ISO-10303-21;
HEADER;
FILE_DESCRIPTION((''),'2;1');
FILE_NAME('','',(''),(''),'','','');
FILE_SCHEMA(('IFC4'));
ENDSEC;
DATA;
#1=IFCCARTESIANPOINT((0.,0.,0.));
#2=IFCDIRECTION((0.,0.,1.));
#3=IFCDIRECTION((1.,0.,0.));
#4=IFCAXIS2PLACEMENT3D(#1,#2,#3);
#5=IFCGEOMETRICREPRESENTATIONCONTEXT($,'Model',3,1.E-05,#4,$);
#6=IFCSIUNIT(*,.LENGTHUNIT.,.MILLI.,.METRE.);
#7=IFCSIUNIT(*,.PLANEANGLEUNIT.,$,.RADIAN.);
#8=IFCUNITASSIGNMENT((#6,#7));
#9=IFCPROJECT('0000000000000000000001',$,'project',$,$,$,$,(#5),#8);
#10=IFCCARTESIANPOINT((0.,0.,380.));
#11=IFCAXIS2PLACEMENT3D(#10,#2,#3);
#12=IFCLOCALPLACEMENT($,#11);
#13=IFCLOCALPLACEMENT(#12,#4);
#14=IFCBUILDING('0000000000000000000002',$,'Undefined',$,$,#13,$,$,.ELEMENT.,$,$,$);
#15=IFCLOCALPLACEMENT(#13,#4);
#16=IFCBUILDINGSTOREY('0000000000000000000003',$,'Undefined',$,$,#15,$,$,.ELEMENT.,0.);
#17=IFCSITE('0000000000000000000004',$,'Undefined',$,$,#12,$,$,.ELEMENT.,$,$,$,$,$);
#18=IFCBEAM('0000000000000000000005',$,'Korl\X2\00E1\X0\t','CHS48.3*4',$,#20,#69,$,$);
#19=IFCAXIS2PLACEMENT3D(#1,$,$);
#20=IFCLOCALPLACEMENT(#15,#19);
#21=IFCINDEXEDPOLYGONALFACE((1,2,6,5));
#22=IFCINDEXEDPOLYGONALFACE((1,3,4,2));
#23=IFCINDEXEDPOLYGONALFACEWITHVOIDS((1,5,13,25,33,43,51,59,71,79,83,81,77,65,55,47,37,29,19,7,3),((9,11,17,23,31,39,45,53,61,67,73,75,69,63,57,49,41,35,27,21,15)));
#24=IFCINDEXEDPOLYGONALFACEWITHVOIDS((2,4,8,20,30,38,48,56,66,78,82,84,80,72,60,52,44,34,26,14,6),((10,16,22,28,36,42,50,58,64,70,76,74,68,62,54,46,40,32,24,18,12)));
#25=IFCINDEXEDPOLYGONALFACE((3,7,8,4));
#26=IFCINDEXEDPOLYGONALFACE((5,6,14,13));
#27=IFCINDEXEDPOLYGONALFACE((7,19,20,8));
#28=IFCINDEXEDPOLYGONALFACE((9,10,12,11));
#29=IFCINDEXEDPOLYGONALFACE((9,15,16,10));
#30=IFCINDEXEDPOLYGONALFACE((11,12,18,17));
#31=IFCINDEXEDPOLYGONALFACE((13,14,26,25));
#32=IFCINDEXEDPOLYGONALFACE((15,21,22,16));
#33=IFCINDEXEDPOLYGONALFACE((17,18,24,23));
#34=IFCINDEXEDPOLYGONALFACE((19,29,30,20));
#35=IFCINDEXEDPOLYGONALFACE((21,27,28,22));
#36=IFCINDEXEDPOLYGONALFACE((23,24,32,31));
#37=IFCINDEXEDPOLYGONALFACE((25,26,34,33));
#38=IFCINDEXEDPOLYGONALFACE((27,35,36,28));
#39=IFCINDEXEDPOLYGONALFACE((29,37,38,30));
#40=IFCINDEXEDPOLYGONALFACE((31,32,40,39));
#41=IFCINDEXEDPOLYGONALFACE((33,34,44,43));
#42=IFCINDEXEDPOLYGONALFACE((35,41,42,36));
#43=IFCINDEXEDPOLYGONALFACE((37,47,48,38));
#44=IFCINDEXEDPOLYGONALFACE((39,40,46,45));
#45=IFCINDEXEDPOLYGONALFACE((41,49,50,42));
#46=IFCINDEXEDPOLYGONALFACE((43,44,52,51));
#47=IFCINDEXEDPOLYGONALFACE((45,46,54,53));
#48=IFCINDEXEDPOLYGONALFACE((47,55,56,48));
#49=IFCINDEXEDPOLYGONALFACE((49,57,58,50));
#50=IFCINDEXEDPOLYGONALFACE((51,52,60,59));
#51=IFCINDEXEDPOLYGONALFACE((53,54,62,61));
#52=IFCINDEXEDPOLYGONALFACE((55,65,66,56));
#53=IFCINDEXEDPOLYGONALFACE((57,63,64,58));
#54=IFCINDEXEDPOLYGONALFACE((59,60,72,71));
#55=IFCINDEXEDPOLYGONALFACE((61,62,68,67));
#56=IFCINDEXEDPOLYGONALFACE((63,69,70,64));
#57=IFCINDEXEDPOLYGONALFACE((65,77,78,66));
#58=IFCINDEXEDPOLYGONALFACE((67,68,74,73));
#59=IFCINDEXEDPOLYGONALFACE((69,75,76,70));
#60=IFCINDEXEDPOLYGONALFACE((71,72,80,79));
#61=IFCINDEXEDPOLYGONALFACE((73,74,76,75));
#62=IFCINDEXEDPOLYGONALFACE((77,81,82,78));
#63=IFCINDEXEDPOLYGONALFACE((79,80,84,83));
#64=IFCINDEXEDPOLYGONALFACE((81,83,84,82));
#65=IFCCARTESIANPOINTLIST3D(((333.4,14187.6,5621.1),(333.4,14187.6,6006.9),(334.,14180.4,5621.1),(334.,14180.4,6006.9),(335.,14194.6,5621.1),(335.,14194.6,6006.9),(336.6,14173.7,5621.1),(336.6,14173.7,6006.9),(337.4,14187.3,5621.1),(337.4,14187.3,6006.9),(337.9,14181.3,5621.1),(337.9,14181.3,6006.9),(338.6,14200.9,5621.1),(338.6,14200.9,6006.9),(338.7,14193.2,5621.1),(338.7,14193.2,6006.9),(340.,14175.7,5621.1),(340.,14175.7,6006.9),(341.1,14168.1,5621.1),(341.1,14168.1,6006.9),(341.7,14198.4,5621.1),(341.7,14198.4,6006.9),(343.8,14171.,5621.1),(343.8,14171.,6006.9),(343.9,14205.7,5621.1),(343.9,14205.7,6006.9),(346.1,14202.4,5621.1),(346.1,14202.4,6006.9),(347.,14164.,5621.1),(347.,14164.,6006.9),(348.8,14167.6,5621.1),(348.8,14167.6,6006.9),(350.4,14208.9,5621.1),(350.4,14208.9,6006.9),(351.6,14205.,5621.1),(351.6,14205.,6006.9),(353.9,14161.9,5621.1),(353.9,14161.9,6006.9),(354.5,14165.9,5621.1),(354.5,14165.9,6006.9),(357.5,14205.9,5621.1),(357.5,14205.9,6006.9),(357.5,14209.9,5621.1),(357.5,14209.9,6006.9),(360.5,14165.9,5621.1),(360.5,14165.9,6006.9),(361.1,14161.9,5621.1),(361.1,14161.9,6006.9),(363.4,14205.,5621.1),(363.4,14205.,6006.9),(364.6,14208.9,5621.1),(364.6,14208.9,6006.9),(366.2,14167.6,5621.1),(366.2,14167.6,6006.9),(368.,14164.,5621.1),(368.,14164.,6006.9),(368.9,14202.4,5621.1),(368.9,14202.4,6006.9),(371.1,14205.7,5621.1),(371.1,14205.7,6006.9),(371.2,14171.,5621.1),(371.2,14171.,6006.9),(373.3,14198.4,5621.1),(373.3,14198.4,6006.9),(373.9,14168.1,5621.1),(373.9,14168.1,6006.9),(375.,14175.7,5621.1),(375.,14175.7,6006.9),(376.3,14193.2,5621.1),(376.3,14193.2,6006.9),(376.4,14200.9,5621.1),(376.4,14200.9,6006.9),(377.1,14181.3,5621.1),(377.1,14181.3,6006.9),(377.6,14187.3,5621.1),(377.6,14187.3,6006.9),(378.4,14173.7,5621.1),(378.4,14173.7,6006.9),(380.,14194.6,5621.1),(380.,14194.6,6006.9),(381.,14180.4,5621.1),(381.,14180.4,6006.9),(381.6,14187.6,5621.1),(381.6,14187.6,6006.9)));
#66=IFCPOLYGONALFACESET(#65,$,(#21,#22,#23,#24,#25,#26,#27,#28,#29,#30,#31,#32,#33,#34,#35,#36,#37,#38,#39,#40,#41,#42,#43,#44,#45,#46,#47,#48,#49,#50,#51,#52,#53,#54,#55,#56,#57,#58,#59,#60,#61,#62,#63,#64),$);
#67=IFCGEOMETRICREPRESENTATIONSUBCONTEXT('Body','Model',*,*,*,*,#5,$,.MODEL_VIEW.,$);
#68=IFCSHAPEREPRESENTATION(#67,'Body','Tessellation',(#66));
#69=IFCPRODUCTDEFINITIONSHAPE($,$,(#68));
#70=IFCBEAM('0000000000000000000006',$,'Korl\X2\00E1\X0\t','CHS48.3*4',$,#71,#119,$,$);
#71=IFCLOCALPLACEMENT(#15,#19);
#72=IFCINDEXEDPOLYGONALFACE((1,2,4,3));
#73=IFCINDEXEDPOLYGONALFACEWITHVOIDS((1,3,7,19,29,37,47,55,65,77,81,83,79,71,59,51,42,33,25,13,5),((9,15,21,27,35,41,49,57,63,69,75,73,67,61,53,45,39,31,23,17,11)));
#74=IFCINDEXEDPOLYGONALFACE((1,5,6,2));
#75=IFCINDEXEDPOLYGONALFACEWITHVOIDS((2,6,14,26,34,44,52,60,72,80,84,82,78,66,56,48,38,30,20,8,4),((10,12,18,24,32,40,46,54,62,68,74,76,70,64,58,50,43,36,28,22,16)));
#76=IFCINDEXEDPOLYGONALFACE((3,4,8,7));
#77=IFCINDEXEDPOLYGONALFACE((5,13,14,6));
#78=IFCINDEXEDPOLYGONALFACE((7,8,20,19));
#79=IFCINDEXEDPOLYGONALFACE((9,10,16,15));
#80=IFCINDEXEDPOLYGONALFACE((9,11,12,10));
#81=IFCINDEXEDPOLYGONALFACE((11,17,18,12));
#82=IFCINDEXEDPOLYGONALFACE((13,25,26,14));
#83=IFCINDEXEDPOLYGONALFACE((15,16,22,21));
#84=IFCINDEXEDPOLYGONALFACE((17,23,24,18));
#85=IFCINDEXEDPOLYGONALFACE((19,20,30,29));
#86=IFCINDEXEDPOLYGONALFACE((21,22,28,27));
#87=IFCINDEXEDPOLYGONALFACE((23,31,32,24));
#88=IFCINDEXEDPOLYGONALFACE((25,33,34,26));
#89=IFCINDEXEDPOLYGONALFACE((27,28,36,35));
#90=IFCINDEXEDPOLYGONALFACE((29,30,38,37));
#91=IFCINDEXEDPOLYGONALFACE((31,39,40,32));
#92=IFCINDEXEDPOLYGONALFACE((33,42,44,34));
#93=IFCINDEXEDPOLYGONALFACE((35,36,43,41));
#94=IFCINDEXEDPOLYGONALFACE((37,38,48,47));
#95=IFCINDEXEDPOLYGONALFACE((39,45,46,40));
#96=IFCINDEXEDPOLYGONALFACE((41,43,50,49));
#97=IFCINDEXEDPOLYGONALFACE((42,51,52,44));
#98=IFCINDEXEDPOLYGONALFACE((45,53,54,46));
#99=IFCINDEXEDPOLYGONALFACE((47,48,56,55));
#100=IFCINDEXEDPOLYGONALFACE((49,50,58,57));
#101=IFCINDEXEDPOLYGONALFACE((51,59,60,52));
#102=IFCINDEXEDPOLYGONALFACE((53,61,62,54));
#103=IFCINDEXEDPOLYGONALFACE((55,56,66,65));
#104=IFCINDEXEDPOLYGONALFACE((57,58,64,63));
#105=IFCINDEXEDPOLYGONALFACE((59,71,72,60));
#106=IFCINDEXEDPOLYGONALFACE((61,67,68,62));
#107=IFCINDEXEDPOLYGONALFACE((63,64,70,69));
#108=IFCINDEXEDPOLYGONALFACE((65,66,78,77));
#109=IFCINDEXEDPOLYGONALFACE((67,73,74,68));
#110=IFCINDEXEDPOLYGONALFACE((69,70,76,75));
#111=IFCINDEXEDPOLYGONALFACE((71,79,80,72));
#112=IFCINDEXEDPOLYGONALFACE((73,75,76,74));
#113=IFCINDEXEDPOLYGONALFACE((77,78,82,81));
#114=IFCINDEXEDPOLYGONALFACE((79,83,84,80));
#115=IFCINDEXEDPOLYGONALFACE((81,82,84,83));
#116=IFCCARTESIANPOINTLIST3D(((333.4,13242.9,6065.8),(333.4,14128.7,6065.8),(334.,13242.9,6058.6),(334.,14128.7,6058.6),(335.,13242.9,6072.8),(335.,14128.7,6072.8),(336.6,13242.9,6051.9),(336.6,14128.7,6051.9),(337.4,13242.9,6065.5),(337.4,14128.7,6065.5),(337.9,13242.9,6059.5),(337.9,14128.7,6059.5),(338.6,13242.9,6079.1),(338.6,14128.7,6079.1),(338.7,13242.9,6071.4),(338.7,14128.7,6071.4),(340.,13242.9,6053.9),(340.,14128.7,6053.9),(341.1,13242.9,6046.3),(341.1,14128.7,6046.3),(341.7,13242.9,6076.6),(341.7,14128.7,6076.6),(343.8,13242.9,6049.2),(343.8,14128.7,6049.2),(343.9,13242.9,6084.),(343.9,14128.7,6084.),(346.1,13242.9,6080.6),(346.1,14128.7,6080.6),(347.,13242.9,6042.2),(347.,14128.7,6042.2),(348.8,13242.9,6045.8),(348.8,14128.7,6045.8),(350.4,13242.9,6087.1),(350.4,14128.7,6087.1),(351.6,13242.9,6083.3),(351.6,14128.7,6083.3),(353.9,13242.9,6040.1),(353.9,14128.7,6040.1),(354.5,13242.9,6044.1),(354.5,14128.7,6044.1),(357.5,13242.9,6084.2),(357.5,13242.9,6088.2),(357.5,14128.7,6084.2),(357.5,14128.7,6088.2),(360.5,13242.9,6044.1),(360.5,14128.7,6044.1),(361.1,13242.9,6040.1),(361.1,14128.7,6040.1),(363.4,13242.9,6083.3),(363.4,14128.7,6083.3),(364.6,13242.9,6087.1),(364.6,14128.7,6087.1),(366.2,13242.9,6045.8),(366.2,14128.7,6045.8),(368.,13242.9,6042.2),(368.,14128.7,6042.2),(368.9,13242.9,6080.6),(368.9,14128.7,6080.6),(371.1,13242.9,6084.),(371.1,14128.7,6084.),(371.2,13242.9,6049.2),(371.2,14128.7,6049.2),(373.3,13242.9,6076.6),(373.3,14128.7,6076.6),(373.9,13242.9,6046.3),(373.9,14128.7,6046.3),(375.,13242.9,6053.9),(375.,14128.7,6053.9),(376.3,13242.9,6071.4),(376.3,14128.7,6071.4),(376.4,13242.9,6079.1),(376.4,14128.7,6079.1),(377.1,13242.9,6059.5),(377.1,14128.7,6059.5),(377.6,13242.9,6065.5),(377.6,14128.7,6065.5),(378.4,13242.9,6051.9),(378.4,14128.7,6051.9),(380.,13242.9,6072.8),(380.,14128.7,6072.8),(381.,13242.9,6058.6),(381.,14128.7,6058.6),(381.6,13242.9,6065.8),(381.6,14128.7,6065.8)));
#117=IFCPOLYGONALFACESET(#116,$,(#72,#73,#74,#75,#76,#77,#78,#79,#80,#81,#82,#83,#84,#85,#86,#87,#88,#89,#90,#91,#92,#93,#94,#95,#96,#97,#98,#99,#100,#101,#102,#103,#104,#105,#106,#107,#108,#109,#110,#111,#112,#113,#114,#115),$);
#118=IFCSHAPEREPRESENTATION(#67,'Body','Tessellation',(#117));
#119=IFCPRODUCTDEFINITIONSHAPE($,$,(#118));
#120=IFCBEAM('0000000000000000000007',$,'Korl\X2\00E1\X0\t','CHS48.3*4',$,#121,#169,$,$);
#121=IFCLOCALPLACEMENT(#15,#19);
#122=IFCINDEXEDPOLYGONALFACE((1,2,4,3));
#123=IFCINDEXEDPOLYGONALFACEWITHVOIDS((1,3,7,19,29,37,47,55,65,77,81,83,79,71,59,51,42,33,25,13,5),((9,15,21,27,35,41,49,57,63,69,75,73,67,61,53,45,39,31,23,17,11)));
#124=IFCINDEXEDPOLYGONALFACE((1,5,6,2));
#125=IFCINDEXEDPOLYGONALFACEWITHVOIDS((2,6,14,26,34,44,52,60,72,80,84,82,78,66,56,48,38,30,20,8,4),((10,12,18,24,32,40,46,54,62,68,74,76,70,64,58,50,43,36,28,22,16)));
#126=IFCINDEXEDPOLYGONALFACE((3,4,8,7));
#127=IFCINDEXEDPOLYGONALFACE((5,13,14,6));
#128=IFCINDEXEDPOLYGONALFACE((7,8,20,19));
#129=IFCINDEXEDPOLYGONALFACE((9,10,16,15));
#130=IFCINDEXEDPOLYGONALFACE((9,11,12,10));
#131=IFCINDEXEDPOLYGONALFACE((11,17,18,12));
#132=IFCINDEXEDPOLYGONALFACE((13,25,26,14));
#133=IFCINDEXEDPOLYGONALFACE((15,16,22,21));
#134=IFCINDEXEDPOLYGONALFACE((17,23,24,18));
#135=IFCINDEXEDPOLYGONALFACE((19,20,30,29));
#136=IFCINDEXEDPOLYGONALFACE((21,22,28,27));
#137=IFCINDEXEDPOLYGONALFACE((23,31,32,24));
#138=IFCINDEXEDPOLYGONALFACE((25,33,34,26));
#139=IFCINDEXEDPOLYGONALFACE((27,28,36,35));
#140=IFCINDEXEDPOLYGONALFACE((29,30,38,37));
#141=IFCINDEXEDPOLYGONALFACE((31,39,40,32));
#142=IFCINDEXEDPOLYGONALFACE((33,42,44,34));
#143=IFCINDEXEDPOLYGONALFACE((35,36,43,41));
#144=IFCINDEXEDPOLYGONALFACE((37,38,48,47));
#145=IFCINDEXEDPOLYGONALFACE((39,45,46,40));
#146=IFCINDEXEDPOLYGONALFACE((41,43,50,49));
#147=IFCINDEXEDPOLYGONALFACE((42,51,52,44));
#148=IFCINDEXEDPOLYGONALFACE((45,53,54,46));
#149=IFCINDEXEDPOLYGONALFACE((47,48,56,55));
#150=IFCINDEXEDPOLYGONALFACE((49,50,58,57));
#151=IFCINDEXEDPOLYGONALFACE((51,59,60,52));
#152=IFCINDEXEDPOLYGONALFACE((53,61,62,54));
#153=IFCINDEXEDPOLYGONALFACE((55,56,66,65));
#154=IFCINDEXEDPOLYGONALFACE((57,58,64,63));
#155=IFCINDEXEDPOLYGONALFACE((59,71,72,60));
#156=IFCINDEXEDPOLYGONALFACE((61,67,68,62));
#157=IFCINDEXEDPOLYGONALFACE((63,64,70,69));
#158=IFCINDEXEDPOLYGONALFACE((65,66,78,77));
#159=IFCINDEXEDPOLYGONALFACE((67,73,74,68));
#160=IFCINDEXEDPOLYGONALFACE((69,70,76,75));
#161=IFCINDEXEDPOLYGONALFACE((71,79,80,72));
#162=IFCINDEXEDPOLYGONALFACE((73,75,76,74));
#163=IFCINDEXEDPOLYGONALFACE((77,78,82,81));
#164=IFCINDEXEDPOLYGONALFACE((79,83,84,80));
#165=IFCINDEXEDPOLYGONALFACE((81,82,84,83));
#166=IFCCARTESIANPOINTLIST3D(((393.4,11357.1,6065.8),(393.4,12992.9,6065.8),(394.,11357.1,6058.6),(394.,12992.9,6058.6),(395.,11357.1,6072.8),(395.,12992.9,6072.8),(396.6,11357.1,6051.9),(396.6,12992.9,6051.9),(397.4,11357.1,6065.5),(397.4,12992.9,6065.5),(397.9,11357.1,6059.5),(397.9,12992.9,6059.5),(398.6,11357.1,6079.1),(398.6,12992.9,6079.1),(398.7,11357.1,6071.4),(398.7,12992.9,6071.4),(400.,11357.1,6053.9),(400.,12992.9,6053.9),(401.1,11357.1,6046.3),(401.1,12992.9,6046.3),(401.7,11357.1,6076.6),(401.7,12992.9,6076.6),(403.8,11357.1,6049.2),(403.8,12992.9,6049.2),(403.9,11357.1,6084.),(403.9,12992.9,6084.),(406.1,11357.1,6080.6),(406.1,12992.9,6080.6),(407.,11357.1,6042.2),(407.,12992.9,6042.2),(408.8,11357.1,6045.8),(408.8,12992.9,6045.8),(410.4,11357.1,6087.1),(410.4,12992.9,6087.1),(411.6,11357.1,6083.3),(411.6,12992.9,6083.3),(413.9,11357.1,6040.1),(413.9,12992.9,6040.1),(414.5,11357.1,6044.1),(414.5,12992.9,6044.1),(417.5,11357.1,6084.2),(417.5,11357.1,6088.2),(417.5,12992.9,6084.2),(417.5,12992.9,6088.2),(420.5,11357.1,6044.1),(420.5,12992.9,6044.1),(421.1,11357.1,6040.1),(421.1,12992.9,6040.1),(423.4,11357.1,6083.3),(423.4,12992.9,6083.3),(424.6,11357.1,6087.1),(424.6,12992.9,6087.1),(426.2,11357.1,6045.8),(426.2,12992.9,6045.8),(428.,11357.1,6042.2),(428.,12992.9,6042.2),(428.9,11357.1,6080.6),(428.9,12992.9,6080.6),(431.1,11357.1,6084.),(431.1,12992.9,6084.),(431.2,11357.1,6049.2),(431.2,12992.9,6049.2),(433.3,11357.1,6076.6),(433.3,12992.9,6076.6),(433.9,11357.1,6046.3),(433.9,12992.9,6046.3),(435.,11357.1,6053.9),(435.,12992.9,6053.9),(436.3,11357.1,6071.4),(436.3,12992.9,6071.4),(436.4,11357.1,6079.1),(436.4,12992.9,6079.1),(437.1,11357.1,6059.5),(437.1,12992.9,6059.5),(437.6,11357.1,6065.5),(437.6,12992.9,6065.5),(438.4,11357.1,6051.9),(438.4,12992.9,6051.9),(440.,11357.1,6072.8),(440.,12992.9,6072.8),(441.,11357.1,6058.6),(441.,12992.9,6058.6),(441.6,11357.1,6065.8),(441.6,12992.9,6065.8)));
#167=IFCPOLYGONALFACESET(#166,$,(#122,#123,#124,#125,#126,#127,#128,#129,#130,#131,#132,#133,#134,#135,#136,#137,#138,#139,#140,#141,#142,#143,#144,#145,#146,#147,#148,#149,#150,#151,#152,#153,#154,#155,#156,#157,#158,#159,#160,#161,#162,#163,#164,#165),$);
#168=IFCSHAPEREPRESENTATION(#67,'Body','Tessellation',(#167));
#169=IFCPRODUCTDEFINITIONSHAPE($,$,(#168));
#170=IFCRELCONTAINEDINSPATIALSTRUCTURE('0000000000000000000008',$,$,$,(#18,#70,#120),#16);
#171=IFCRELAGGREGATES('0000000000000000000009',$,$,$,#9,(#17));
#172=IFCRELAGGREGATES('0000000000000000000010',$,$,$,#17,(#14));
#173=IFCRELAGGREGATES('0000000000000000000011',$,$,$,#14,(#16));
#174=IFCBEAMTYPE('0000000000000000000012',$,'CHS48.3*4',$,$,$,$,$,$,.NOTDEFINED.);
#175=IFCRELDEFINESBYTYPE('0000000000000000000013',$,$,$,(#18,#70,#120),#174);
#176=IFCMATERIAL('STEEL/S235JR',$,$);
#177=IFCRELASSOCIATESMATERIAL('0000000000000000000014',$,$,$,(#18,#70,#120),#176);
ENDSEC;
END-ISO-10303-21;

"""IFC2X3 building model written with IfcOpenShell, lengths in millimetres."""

from ifc_helpers import new_model, si_unit, frame, origin_with_axes, origin_2d_with_axis, place, context, subcontext, project, spatial, hollow_circle, extrude, material, type_object, element, save


model = new_model("IFC2X3")

# Units and contexts
model_context = context("Model", 3, precision=1e-05, world=origin_with_axes())
body_context = subcontext(model_context, "Body", "Model", "MODEL_VIEW")
ifc_project = project(units=[si_unit("LENGTHUNIT", "METRE", prefix="MILLI"), si_unit("PLANEANGLEUNIT", "RADIAN")], contexts=[model_context])

# Site, building, storey
site_placement = place(None, frame((0.0, 0.0, 380.0), z_axis=(0.0, 0.0, 1.0), x_axis=(1.0, 0.0, 0.0)))
site = spatial("IfcSite", under=ifc_project, at=site_placement, Name="Undefined", CompositionType="ELEMENT")
building_placement = place(site_placement, origin_with_axes())
building = spatial("IfcBuilding", under=site, at=building_placement, Name="Undefined", CompositionType="ELEMENT")
storey_placement = place(building_placement, origin_with_axes())
storey = spatial("IfcBuildingStorey", under=building, at=storey_placement, Name="Undefined", CompositionType="ELEMENT", Elevation=0.0)

# Shared definitions
ifc_material_1 = material(Name="STEEL/S235JR")

# Beams
beam_type_1 = type_object("IfcBeamType", Name="CHS48.3*4", PredefinedType="NOTDEFINED")
beam_1_placement = place(storey_placement, frame((357.5, 14185.8, 6006.9), z_axis=(-1.0, 0.0, 0.0), x_axis=(0.0, 0.0, -1.0)))
element("IfcBeam", 1, at=beam_1_placement, inside=storey, type_object=beam_type_1, material=ifc_material_1, Name="Korlát", Description="CHS48.3*4", context=body_context, shape_type="SweptSolid", body=[
    extrude(hollow_circle(Radius=24.1, WallThickness=4.0, at=origin_2d_with_axis()), frame((385.8, 0.0, 0.0), z_axis=(-1.0, 0.0, 0.0), x_axis=(0.0, -1.0, 0.0)), (0.0, 0.0, 1.0), 385.8),
])
beam_2_placement = place(storey_placement, frame((357.5, 13242.9, 6064.0), z_axis=(-1.0, 0.0, 0.0), x_axis=(0.0, 1.0, 0.0)))
element("IfcBeam", 2, at=beam_2_placement, inside=storey, type_object=beam_type_1, material=ifc_material_1, Name="Korlát", Description="CHS48.3*4", context=body_context, shape_type="SweptSolid", body=[
    extrude(hollow_circle(Radius=24.1, WallThickness=4.0, at=origin_2d_with_axis()), frame((885.8, 0.0, 0.0), z_axis=(-1.0, 0.0, 0.0), x_axis=(0.0, -1.0, 0.0)), (0.0, 0.0, 1.0), 885.8),
])
beam_3_placement = place(storey_placement, frame((417.5, 12992.9, 6064.0), z_axis=(1.0, 0.0, 0.0), x_axis=(0.0, -1.0, 0.0)))
element("IfcBeam", 3, at=beam_3_placement, inside=storey, type_object=beam_type_1, material=ifc_material_1, Name="Korlát", Description="CHS48.3*4", context=body_context, shape_type="SweptSolid", body=[
    extrude(hollow_circle(Radius=24.1, WallThickness=4.0, at=origin_2d_with_axis()), frame((1635.8, 0.0, 0.0), z_axis=(-1.0, 0.0, 0.0), x_axis=(0.0, -1.0, 0.0)), (0.0, 0.0, 1.0), 1635.8),
])

save(model, "model.ifc")
